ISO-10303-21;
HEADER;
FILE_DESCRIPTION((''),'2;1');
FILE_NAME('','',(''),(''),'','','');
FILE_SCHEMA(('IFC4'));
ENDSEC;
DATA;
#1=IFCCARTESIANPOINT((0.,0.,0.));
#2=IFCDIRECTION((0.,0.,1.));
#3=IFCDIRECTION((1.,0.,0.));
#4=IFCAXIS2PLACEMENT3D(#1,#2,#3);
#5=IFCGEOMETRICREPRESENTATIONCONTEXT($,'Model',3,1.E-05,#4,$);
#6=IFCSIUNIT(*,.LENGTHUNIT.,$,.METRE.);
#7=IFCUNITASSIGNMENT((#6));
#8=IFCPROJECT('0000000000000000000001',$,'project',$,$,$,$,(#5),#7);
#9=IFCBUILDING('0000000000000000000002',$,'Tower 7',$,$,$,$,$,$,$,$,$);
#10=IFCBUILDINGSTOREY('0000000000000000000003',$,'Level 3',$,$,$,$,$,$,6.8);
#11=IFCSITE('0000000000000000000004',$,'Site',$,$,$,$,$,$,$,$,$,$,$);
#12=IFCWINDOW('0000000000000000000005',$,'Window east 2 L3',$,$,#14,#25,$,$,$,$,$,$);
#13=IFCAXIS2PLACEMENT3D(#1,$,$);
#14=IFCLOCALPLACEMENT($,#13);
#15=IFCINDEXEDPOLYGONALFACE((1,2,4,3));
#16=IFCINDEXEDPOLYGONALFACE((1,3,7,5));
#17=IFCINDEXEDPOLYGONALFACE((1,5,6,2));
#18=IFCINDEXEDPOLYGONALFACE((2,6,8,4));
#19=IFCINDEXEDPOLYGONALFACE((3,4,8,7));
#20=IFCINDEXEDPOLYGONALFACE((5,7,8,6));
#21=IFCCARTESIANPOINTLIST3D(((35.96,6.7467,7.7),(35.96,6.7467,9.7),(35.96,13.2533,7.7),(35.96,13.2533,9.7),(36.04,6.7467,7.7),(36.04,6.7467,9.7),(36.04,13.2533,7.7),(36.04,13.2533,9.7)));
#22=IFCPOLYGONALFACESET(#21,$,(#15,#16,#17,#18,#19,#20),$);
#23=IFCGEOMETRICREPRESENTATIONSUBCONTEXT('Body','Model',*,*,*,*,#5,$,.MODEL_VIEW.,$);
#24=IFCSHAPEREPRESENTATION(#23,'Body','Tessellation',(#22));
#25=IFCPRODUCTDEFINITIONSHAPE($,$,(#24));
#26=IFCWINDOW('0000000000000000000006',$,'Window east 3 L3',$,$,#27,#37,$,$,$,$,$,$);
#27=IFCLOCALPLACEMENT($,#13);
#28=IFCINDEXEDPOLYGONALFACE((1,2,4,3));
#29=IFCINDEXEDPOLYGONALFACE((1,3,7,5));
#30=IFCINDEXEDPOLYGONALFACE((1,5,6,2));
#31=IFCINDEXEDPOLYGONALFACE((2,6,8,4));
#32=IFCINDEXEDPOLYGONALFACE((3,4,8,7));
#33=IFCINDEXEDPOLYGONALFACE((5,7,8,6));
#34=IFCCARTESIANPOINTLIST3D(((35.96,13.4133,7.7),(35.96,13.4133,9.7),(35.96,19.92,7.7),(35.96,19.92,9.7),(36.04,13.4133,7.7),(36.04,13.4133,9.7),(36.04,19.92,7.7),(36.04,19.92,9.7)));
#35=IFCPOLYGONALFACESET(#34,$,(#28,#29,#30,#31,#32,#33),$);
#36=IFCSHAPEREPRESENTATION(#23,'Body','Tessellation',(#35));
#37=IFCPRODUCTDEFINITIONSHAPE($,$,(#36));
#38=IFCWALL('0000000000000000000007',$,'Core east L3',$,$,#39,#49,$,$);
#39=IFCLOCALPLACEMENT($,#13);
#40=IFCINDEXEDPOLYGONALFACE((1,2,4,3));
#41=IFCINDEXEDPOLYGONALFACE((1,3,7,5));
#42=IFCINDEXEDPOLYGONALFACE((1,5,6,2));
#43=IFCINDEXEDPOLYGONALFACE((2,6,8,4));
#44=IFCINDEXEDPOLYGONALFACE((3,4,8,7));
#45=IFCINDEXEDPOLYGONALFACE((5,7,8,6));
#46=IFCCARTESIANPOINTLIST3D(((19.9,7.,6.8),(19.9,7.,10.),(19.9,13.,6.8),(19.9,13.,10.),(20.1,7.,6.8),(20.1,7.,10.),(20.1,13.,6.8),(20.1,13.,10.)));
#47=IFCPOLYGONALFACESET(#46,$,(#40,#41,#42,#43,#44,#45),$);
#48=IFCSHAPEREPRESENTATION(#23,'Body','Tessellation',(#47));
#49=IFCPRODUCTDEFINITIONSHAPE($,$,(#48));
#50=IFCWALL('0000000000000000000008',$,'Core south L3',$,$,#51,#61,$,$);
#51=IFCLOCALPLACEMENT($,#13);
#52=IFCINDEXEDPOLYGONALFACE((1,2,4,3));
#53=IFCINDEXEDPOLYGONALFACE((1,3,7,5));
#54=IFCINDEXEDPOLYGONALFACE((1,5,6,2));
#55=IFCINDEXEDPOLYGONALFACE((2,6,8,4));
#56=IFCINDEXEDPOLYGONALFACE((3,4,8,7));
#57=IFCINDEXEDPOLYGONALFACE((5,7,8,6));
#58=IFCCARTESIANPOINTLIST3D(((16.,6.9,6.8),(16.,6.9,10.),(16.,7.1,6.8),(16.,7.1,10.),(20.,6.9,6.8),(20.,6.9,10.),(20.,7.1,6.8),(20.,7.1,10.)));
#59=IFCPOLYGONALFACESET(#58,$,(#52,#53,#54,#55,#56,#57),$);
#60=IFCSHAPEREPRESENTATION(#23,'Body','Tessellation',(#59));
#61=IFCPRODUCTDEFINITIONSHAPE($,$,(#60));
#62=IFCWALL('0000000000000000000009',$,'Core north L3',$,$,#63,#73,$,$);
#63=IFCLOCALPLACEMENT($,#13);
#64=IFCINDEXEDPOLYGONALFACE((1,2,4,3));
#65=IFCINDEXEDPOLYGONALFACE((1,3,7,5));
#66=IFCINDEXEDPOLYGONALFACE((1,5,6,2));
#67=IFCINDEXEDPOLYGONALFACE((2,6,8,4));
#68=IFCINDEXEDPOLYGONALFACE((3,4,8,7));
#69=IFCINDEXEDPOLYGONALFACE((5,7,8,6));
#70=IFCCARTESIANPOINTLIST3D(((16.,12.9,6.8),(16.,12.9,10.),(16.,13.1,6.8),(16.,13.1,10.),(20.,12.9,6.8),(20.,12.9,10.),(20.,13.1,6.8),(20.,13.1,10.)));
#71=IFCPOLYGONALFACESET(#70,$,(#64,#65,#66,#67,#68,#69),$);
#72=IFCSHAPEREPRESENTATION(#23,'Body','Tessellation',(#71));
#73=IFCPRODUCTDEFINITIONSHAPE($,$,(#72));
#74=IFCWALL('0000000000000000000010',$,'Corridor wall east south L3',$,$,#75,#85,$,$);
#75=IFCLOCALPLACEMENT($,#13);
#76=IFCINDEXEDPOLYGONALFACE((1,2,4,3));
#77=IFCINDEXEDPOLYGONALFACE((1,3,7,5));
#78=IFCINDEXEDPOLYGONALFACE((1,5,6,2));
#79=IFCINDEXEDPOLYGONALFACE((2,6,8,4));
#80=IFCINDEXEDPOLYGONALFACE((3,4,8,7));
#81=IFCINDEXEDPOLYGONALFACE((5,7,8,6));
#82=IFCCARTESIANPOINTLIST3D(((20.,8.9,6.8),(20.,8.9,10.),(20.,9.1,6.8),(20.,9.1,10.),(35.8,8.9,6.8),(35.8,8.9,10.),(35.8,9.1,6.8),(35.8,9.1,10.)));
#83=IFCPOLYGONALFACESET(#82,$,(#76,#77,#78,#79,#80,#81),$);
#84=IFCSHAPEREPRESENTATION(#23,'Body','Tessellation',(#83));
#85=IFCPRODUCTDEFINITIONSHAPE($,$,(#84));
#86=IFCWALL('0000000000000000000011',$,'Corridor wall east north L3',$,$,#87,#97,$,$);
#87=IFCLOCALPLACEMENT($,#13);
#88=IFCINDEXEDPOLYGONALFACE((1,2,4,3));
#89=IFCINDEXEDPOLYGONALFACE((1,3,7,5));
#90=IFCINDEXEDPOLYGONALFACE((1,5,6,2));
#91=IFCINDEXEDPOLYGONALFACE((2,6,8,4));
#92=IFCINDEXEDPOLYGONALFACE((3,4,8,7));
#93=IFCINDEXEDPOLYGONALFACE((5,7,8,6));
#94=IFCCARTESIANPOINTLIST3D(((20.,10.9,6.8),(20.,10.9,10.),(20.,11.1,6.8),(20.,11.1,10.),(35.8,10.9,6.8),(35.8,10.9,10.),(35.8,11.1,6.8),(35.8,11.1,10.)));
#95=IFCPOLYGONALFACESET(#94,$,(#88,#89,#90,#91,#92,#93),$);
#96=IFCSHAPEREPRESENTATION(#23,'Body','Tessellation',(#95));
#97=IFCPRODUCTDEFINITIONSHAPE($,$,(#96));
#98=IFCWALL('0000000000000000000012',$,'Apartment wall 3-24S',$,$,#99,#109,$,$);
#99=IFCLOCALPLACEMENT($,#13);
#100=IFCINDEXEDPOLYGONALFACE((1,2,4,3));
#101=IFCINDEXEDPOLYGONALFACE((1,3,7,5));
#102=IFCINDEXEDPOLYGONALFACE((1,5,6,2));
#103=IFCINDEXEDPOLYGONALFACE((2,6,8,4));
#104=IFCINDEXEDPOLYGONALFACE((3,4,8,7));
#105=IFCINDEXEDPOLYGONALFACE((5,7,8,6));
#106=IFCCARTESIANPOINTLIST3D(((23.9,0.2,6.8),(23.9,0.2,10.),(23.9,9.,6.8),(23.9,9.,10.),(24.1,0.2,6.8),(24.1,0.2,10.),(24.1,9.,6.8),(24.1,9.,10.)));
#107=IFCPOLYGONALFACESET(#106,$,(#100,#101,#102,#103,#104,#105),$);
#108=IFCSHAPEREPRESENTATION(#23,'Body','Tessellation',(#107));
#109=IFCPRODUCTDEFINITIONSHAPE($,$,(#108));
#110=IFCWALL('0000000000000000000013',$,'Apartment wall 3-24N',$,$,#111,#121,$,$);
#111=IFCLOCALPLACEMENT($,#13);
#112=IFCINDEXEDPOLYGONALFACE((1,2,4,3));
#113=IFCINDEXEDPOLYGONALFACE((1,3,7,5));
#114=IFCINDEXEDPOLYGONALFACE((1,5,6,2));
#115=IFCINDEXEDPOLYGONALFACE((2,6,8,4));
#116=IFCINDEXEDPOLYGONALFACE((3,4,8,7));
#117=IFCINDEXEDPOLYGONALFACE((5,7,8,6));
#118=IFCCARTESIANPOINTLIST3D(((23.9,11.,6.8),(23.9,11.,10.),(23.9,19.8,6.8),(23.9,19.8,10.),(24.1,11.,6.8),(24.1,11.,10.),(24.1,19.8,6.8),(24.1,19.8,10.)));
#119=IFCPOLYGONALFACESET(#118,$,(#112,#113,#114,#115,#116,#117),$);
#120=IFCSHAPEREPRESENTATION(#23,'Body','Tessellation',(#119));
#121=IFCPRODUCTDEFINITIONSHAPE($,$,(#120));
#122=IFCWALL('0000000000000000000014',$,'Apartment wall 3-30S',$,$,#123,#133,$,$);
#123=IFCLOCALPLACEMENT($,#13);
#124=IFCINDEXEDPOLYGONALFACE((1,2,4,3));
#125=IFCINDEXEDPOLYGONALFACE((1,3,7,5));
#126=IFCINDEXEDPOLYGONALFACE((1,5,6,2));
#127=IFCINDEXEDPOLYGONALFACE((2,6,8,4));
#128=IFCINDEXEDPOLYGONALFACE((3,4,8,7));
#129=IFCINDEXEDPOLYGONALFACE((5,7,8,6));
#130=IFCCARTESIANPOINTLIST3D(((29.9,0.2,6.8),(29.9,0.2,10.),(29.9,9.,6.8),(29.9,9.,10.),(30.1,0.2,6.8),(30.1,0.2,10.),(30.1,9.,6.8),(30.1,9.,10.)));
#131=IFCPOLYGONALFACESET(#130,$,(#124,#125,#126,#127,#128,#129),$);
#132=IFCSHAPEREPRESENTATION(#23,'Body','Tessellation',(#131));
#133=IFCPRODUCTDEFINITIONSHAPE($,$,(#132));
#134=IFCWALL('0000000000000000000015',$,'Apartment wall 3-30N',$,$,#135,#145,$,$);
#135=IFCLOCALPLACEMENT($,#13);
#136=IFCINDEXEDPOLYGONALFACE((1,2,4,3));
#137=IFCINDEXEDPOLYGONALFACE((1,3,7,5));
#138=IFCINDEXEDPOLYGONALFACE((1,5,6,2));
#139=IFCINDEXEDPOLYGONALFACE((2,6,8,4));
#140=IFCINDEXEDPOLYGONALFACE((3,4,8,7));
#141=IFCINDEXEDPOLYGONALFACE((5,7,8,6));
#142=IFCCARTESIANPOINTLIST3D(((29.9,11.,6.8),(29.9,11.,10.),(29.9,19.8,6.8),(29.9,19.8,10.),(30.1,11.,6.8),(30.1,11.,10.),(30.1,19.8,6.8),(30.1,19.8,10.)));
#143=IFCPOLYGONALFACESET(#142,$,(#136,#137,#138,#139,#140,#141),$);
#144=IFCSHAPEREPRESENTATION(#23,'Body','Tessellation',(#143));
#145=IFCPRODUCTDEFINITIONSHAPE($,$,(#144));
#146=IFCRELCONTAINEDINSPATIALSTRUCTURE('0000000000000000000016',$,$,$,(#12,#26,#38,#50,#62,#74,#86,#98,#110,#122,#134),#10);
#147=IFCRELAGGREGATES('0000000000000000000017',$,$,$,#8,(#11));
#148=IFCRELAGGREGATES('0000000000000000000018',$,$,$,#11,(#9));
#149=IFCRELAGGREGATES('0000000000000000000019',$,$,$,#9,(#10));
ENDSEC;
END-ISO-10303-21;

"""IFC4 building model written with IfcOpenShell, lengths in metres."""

from ifc_helpers import new_model, si_unit, frame, origin, origin_with_axes, origin_2d, place, context, subcontext, project, spatial, rectangle, extrude, element, save


model = new_model("IFC4")

# Units and contexts
model_context = context("Model", 3, precision=1e-05, world=origin_with_axes())
body_context = subcontext(model_context, "Body", "Model", "MODEL_VIEW")
ifc_project = project(units=[si_unit("LENGTHUNIT", "METRE")], contexts=[model_context])

# Site, building, storey
site = spatial("IfcSite", under=ifc_project, Name="Site")
building = spatial("IfcBuilding", under=site, Name="Tower 7")
storey = spatial("IfcBuildingStorey", under=building, Name="Level 3", Elevation=6.8)

# Windows
for number, where, z_axis, x_axis, name in (
    (1, (36.0, 10.0, 7.7), (0.0, 0.0, 1.0), (1.0, 0.0, 0.0), "Window east 2 L3"),
):
    element("IfcWindow", number, at=place(None, frame(where, z_axis=z_axis, x_axis=x_axis)), inside=storey, Name=name, context=body_context, shape_type="SweptSolid", body=[
        extrude(rectangle(XDim=0.08, YDim=6.5067, at=origin_2d()), origin(), (0.0, 0.0, 1.0), 2.0),
    ])
window_placement = place(None, frame((36.0, 16.6667, 7.7), z_axis=(0.0, 0.0, 1.0), x_axis=(1.0, 0.0, 0.0)))
element("IfcWindow", 2, at=window_placement, inside=storey, Name="Window east 3 L3", context=body_context, shape_type="SweptSolid", body=[
    extrude(rectangle(XDim=0.08, YDim=6.5067, at=origin_2d()), origin(), (0.0, 0.0, 1.0), 2.0),
])

# Walls
wall_1_placement = place(None, frame((20.0, 10.0, 6.8), z_axis=(0.0, 0.0, 1.0), x_axis=(1.0, 0.0, 0.0)))
element("IfcWall", 3, at=wall_1_placement, inside=storey, Name="Core east L3", context=body_context, shape_type="SweptSolid", body=[
    extrude(rectangle(XDim=0.2, YDim=6.0, at=origin_2d()), origin(), (0.0, 0.0, 1.0), 3.2),
])
for number, where, z_axis, x_axis, name in (
    (4, (18.0, 7.0, 6.8), (0.0, 0.0, 1.0), (1.0, 0.0, 0.0), "Core south L3"),
    (5, (18.0, 13.0, 6.8), (0.0, 0.0, 1.0), (1.0, 0.0, 0.0), "Core north L3"),
):
    element("IfcWall", number, at=place(None, frame(where, z_axis=z_axis, x_axis=x_axis)), inside=storey, Name=name, context=body_context, shape_type="SweptSolid", body=[
        extrude(rectangle(XDim=4.0, YDim=0.2, at=origin_2d()), origin(), (0.0, 0.0, 1.0), 3.2),
    ])
for number, where, z_axis, x_axis, name in (
    (6, (27.9, 9.0, 6.8), (0.0, 0.0, 1.0), (1.0, 0.0, 0.0), "Corridor wall east south L3"),
    (7, (27.9, 11.0, 6.8), (0.0, 0.0, 1.0), (1.0, 0.0, 0.0), "Corridor wall east north L3"),
):
    element("IfcWall", number, at=place(None, frame(where, z_axis=z_axis, x_axis=x_axis)), inside=storey, Name=name, context=body_context, shape_type="SweptSolid", body=[
        extrude(rectangle(XDim=15.8, YDim=0.2, at=origin_2d()), origin(), (0.0, 0.0, 1.0), 3.2),
    ])
for number, where, z_axis, x_axis, name in (
    (8, (24.0, 4.6, 6.8), (0.0, 0.0, 1.0), (1.0, 0.0, 0.0), "Apartment wall 3-24S"),
    (9, (24.0, 15.4, 6.8), (0.0, 0.0, 1.0), (1.0, 0.0, 0.0), "Apartment wall 3-24N"),
    (10, (30.0, 4.6, 6.8), (0.0, 0.0, 1.0), (1.0, 0.0, 0.0), "Apartment wall 3-30S"),
    (11, (30.0, 15.4, 6.8), (0.0, 0.0, 1.0), (1.0, 0.0, 0.0), "Apartment wall 3-30N"),
):
    element("IfcWall", number, at=place(None, frame(where, z_axis=z_axis, x_axis=x_axis)), inside=storey, Name=name, context=body_context, shape_type="SweptSolid", body=[
        extrude(rectangle(XDim=0.2, YDim=8.8, at=origin_2d()), origin(), (0.0, 0.0, 1.0), 3.2),
    ])

save(model, "model.ifc")
